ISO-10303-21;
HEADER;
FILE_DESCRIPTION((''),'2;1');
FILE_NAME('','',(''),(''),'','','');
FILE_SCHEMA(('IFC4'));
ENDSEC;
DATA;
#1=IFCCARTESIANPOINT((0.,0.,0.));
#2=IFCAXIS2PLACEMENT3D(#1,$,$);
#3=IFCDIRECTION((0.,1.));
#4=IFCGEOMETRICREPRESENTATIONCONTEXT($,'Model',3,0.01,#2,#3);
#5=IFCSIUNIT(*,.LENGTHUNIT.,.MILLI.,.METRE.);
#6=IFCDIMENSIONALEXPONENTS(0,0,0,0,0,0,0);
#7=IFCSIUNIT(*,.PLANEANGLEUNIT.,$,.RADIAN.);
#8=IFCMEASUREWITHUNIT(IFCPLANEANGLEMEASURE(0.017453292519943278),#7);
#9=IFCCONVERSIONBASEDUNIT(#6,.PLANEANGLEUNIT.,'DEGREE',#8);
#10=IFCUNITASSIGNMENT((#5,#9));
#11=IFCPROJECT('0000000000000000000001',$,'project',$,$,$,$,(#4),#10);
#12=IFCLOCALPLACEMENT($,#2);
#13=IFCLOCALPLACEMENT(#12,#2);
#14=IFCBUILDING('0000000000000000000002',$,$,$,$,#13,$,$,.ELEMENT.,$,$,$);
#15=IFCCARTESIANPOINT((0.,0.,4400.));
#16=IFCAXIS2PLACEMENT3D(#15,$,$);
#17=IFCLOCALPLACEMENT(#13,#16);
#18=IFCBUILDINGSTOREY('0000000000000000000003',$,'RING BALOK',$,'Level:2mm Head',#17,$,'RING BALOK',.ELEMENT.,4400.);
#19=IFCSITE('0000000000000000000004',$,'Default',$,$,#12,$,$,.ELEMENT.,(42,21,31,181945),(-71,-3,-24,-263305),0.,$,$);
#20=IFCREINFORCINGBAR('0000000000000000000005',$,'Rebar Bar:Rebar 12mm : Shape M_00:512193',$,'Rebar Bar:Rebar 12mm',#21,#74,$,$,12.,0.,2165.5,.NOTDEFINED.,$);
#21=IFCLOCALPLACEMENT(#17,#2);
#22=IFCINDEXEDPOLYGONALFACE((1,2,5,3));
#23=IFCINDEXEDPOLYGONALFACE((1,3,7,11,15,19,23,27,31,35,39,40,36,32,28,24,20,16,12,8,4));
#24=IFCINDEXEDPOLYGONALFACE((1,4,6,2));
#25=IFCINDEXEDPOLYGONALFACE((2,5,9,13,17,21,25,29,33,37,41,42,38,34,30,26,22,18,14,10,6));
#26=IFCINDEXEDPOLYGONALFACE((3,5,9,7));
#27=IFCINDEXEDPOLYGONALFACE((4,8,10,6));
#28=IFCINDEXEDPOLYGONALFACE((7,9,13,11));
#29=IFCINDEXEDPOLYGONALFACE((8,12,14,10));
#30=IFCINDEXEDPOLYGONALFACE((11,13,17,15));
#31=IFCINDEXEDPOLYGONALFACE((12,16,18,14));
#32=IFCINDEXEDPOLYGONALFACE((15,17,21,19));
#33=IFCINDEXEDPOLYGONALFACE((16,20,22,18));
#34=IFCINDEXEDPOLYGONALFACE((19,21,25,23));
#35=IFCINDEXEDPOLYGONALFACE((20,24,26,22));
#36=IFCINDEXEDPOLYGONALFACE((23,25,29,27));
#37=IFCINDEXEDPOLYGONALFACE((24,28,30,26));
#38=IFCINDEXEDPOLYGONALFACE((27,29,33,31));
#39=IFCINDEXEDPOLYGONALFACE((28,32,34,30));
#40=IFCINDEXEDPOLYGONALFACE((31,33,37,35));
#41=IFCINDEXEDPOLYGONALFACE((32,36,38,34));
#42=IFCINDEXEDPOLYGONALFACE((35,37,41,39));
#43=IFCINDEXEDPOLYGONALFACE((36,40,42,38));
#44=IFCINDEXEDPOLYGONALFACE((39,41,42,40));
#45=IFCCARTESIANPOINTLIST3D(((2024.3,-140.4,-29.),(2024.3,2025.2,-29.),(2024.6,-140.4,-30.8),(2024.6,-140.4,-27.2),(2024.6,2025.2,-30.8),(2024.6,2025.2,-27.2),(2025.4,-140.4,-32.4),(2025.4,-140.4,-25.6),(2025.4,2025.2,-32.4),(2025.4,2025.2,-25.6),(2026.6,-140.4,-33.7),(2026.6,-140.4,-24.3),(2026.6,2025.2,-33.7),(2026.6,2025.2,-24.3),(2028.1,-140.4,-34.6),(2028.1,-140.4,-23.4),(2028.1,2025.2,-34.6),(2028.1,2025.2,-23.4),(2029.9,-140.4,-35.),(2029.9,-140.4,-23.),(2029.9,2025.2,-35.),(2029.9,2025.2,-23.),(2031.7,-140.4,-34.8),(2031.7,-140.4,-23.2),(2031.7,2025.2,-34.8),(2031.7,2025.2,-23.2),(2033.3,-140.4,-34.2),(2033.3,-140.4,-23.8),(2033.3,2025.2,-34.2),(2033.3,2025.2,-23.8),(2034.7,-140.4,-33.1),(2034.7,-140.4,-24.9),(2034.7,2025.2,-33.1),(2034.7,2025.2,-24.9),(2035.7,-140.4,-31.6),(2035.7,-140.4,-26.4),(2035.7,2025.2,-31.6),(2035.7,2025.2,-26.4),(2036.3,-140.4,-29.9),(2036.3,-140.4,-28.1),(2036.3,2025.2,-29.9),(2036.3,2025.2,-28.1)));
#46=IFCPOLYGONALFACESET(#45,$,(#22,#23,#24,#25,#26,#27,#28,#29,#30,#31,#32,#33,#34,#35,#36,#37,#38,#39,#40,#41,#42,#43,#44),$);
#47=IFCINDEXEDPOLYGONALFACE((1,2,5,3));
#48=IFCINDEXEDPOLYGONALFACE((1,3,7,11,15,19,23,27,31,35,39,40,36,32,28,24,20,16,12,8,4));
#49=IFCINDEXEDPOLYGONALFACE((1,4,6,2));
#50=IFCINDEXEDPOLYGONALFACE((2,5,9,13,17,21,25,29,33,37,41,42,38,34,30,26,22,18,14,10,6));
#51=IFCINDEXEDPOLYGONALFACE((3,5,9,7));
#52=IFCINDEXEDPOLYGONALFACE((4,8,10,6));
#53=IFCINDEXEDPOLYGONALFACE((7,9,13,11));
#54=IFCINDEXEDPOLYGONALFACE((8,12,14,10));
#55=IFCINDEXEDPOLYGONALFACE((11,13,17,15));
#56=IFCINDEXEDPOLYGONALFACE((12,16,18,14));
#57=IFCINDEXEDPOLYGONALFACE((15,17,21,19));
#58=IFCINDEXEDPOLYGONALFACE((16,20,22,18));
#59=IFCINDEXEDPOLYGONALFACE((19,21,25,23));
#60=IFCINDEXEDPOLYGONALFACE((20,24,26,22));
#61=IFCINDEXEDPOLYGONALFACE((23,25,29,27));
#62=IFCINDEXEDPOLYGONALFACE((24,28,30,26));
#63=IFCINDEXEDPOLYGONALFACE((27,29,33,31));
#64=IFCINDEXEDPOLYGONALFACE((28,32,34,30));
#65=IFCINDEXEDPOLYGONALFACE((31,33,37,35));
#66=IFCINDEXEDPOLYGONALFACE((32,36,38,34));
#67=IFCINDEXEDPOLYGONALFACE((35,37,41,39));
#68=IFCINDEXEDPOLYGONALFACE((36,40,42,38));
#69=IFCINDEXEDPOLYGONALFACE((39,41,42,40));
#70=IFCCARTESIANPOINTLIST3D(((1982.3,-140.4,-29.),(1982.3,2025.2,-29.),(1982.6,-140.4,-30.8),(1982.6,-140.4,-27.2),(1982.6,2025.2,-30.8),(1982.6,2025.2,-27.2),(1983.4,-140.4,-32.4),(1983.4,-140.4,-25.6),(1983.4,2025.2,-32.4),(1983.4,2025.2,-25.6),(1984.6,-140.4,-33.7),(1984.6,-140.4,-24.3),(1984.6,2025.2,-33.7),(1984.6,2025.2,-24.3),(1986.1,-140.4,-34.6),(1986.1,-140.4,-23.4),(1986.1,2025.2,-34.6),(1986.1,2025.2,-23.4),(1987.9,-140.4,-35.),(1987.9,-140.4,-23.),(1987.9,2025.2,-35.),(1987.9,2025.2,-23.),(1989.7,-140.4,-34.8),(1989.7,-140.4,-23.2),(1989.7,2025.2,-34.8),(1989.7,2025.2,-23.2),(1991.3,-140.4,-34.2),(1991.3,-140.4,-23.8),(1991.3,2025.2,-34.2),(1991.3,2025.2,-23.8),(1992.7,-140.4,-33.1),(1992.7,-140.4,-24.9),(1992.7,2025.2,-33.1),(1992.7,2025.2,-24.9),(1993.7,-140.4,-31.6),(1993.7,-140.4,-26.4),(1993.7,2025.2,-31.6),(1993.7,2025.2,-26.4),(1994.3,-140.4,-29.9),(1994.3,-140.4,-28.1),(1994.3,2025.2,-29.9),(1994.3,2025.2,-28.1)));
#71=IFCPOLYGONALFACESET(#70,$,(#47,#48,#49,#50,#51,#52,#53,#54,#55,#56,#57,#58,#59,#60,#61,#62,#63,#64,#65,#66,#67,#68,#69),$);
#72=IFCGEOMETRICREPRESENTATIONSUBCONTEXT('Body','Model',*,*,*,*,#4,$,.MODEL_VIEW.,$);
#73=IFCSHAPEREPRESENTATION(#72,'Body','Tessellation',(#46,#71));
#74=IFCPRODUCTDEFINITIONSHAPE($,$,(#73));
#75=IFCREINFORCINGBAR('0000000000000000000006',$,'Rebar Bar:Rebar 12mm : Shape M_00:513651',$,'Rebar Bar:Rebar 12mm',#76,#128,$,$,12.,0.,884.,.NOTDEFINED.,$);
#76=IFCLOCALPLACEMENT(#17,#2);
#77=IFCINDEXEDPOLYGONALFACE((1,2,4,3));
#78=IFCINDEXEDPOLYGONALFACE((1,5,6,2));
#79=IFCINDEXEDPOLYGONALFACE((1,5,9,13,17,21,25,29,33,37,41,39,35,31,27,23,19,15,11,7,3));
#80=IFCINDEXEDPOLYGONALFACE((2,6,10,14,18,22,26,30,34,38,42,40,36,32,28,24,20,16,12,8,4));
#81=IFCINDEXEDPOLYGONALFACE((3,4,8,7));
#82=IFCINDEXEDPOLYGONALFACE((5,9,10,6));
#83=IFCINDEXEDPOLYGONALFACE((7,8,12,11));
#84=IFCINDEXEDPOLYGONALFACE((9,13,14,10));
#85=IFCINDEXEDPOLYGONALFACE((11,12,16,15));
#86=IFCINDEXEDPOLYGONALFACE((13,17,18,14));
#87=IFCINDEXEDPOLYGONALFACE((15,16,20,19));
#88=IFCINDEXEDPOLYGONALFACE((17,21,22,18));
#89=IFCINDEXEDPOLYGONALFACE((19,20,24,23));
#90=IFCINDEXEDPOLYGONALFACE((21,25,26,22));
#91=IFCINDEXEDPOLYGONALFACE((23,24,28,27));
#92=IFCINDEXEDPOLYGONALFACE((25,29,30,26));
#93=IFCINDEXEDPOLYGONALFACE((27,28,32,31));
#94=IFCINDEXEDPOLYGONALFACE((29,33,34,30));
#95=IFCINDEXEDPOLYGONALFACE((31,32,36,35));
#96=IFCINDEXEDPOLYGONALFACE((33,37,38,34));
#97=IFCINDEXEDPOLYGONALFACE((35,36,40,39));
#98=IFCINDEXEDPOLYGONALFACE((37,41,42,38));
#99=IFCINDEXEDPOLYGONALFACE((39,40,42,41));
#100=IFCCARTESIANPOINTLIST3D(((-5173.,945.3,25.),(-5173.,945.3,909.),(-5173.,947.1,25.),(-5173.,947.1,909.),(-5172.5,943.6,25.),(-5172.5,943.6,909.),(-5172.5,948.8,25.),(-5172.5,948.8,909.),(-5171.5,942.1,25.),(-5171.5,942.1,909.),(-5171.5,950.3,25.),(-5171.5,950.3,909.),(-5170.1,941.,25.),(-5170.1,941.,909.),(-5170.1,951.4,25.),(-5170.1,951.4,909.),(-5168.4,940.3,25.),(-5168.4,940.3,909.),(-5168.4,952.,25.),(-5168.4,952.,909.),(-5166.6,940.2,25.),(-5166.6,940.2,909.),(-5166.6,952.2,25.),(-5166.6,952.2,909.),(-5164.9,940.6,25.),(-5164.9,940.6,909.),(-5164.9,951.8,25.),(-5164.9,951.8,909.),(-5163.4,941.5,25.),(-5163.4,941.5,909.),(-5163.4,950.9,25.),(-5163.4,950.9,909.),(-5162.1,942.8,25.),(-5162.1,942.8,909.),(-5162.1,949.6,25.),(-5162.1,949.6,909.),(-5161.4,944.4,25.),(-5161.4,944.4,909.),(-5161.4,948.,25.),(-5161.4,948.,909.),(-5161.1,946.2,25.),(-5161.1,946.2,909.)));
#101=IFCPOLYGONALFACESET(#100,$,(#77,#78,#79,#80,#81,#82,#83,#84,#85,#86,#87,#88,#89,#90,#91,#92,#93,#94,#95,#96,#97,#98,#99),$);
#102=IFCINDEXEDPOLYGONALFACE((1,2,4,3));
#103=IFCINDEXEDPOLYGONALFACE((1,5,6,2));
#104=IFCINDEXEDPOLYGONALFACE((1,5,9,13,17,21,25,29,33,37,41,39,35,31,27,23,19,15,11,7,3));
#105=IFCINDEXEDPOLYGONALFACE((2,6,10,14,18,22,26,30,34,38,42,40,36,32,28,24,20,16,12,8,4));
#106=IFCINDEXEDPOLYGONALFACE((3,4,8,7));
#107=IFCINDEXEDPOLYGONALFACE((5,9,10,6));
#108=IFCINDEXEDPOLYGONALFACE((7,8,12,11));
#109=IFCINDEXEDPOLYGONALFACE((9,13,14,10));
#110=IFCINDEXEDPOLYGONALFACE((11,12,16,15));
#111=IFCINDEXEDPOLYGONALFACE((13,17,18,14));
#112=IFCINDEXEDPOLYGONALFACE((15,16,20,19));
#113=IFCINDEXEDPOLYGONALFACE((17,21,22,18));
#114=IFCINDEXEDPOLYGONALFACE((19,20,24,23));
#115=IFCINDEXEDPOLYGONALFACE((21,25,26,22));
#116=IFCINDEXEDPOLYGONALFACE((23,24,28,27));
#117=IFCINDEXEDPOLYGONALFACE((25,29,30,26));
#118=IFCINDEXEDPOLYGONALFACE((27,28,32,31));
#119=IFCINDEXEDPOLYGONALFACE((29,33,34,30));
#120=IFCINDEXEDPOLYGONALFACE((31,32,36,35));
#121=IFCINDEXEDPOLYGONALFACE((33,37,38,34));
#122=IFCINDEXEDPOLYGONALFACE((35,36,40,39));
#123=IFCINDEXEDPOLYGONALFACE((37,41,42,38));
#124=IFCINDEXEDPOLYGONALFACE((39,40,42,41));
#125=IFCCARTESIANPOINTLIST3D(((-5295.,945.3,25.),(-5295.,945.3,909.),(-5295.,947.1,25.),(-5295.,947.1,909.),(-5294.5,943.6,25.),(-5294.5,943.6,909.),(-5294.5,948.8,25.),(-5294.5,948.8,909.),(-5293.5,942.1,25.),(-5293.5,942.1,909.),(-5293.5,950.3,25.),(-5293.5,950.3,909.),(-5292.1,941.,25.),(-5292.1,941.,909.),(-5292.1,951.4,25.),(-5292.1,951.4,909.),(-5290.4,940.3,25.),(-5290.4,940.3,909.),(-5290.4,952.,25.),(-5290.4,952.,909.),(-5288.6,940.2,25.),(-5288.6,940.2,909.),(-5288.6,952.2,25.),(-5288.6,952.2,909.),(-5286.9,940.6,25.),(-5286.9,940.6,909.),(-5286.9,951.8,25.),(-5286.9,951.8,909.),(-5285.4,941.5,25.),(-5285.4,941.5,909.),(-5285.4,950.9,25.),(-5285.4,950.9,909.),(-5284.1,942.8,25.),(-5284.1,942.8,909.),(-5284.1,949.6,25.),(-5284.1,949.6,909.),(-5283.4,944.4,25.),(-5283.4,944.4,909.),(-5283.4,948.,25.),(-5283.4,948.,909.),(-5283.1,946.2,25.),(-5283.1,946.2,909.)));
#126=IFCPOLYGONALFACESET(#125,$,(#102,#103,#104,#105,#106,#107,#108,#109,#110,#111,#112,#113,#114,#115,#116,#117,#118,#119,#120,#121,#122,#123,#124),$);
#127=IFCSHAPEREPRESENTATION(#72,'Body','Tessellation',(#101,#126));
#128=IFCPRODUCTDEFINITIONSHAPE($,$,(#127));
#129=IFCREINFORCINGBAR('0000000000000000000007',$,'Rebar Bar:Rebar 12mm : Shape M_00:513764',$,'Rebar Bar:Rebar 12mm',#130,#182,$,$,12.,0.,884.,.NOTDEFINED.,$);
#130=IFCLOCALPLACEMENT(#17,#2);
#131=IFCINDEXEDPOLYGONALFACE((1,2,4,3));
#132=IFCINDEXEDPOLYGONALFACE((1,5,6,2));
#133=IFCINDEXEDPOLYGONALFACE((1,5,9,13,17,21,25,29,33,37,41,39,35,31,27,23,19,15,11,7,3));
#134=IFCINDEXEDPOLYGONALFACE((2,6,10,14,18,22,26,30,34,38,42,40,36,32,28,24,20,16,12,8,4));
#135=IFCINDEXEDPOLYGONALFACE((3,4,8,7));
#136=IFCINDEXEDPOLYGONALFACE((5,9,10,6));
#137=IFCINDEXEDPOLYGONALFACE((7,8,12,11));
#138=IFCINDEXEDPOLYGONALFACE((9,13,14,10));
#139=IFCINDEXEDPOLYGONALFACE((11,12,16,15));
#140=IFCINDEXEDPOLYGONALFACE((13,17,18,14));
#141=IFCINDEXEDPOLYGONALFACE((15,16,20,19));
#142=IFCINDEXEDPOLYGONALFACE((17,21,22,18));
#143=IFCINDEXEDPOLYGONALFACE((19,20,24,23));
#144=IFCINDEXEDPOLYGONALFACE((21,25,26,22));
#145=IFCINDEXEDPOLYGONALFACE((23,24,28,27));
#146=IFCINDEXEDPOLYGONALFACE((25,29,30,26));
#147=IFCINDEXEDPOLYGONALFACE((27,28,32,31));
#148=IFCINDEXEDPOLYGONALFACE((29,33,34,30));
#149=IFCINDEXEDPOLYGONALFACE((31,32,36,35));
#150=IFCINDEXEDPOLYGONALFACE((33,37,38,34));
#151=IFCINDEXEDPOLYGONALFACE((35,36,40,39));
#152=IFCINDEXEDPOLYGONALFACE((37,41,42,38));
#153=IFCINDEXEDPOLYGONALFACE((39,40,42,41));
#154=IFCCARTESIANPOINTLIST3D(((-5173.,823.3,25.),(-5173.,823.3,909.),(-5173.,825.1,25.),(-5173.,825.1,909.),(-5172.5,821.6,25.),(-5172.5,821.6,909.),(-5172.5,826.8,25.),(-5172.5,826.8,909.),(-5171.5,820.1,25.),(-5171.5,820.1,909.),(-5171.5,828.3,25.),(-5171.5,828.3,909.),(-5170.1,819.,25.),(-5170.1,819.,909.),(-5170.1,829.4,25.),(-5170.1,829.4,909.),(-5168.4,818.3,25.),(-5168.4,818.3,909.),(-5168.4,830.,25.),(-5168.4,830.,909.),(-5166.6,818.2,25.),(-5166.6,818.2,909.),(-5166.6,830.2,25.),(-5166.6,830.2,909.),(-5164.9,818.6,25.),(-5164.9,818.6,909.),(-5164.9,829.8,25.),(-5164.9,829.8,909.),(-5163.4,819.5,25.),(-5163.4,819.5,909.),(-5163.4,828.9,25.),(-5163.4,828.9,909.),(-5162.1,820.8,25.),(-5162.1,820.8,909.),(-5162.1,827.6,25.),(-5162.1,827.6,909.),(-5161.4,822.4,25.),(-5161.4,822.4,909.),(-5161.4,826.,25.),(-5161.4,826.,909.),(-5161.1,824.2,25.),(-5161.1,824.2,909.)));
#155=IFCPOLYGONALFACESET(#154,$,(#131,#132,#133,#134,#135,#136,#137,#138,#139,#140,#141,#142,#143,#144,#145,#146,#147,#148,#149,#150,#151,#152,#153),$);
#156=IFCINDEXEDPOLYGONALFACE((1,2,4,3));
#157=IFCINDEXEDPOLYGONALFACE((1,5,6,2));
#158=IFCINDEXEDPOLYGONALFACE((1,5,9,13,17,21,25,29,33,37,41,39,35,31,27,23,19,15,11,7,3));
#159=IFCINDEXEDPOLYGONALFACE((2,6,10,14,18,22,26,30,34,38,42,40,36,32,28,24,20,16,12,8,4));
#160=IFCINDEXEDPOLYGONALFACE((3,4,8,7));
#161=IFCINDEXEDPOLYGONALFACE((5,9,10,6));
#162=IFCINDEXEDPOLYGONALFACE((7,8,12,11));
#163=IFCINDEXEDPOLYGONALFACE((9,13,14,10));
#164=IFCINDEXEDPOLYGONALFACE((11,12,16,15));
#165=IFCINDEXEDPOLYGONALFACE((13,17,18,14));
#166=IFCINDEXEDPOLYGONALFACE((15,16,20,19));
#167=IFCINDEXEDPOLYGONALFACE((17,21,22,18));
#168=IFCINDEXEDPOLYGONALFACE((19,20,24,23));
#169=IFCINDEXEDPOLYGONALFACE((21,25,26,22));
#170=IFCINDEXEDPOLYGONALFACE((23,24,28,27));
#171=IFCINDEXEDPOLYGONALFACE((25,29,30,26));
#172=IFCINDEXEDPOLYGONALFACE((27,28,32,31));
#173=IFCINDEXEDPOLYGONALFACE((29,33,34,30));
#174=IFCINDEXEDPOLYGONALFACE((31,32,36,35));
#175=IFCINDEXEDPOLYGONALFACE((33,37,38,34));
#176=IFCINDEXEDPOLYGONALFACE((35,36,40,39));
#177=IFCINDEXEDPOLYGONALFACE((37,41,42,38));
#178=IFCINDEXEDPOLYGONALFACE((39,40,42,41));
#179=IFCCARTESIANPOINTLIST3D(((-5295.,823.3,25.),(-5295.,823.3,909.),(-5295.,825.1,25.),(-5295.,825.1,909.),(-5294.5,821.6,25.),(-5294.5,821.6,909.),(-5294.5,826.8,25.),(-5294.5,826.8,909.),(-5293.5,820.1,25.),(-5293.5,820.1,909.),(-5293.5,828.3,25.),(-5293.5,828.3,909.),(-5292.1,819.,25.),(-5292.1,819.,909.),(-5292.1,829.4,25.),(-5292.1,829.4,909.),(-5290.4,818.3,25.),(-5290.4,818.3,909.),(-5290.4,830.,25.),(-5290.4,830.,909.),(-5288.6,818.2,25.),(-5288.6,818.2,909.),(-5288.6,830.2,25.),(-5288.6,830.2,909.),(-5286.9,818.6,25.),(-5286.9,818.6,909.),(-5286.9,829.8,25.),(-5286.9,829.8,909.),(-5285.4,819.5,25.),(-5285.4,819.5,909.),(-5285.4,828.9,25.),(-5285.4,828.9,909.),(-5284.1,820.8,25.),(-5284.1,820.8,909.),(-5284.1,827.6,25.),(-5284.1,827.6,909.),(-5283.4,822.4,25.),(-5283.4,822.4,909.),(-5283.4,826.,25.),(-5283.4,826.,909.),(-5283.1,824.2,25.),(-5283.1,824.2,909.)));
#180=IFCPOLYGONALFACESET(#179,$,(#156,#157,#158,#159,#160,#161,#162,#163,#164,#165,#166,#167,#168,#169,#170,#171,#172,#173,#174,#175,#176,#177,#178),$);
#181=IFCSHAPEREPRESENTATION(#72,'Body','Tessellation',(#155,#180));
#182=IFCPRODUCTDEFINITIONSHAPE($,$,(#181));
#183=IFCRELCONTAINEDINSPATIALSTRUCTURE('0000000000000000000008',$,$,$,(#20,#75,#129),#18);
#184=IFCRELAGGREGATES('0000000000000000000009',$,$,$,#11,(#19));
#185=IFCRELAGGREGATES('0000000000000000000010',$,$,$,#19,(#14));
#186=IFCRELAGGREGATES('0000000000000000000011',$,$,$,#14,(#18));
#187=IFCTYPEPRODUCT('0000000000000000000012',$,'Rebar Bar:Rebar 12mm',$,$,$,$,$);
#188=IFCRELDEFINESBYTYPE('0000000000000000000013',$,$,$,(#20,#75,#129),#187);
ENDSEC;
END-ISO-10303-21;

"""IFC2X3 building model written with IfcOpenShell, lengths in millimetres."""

from ifc_helpers import new_model, entity, si_unit, converted_unit, direction, frame, origin, place, context, subcontext, project, spatial, type_object, element, save


model = new_model("IFC2X3")

# Units and contexts
model_context = context("Model", 3, precision=0.01, world=origin(), true_north=direction((0.0, 1.0)))
body_context = subcontext(model_context, "Body", "Model", "MODEL_VIEW")
ifc_project = project(units=[si_unit("LENGTHUNIT", "METRE", prefix="MILLI"), converted_unit("PLANEANGLEUNIT", "DEGREE", entity("IfcPlaneAngleMeasure", 0.017453292519943278), si_unit("PLANEANGLEUNIT", "RADIAN"), dimensions=[0, 0, 0, 0, 0, 0, 0])], contexts=[model_context])

# Site, building, storey
site_placement = place(None, origin())
site = spatial("IfcSite", under=ifc_project, at=site_placement, Name="Default", CompositionType="ELEMENT", RefLatitude=(42, 21, 31, 181945), RefLongitude=(-71, -3, -24, -263305), RefElevation=0.0)
building_placement = place(site_placement, origin())
building = spatial("IfcBuilding", under=site, at=building_placement, CompositionType="ELEMENT")
storey_placement = place(building_placement, frame((0.0, 0.0, 4400.0)))
storey = spatial("IfcBuildingStorey", under=building, at=storey_placement, Name="RING BALOK", ObjectType="Level:2mm Head", LongName="RING BALOK", CompositionType="ELEMENT", Elevation=4400.0)

# Reinforcing bars
type_product_1 = type_object("IfcTypeProduct", Name="Rebar Bar:Rebar 12mm")
reinforcing_bar_1_placement = place(storey_placement, origin())
element("IfcReinforcingBar", 1, at=reinforcing_bar_1_placement, inside=storey, type_object=type_product_1, Name="Rebar Bar:Rebar 12mm : Shape M_00:512193", ObjectType="Rebar Bar:Rebar 12mm", BarLength=2165.5, BarRole="NOTDEFINED", CrossSectionArea=0.0, NominalDiameter=12.0, context=body_context, shape_type="AdvancedSweptSolid", body=[
    entity("IfcSweptDiskSolid", entity("IfcCompositeCurve", [entity("IfcCompositeCurveSegment", "CONTINUOUS", True, entity("IfcPolyline", [entity("IfcCartesianPoint", [2030.3, 2025.2, -29.0]), entity("IfcCartesianPoint", [2030.3, -140.4, -29.0])]))], False), 6.0, None, 0.0, 1.0),
    entity("IfcSweptDiskSolid", entity("IfcCompositeCurve", [entity("IfcCompositeCurveSegment", "CONTINUOUS", True, entity("IfcPolyline", [entity("IfcCartesianPoint", [1988.3, 2025.2, -29.0]), entity("IfcCartesianPoint", [1988.3, -140.4, -29.0])]))], False), 6.0, None, 0.0, 1.0),
])
reinforcing_bar_2_placement = place(storey_placement, origin())
element("IfcReinforcingBar", 2, at=reinforcing_bar_2_placement, inside=storey, type_object=type_product_1, Name="Rebar Bar:Rebar 12mm : Shape M_00:513651", ObjectType="Rebar Bar:Rebar 12mm", BarLength=884.0, BarRole="NOTDEFINED", CrossSectionArea=0.0, NominalDiameter=12.0, context=body_context, shape_type="AdvancedSweptSolid", body=[
    entity("IfcSweptDiskSolid", entity("IfcCompositeCurve", [entity("IfcCompositeCurveSegment", "CONTINUOUS", True, entity("IfcPolyline", [entity("IfcCartesianPoint", [-5167.1, 946.2, 25.0]), entity("IfcCartesianPoint", [-5167.1, 946.2, 909.0])]))], False), 6.0, None, 0.0, 1.0),
    entity("IfcSweptDiskSolid", entity("IfcCompositeCurve", [entity("IfcCompositeCurveSegment", "CONTINUOUS", True, entity("IfcPolyline", [entity("IfcCartesianPoint", [-5289.1, 946.2, 25.0]), entity("IfcCartesianPoint", [-5289.1, 946.2, 909.0])]))], False), 6.0, None, 0.0, 1.0),
])
reinforcing_bar_3_placement = place(storey_placement, origin())
element("IfcReinforcingBar", 3, at=reinforcing_bar_3_placement, inside=storey, type_object=type_product_1, Name="Rebar Bar:Rebar 12mm : Shape M_00:513764", ObjectType="Rebar Bar:Rebar 12mm", BarLength=884.0, BarRole="NOTDEFINED", CrossSectionArea=0.0, NominalDiameter=12.0, context=body_context, shape_type="AdvancedSweptSolid", body=[
    entity("IfcSweptDiskSolid", entity("IfcCompositeCurve", [entity("IfcCompositeCurveSegment", "CONTINUOUS", True, entity("IfcPolyline", [entity("IfcCartesianPoint", [-5167.1, 824.2, 25.0]), entity("IfcCartesianPoint", [-5167.1, 824.2, 909.0])]))], False), 6.0, None, 0.0, 1.0),
    entity("IfcSweptDiskSolid", entity("IfcCompositeCurve", [entity("IfcCompositeCurveSegment", "CONTINUOUS", True, entity("IfcPolyline", [entity("IfcCartesianPoint", [-5289.1, 824.2, 25.0]), entity("IfcCartesianPoint", [-5289.1, 824.2, 909.0])]))], False), 6.0, None, 0.0, 1.0),
])

save(model, "model.ifc")
